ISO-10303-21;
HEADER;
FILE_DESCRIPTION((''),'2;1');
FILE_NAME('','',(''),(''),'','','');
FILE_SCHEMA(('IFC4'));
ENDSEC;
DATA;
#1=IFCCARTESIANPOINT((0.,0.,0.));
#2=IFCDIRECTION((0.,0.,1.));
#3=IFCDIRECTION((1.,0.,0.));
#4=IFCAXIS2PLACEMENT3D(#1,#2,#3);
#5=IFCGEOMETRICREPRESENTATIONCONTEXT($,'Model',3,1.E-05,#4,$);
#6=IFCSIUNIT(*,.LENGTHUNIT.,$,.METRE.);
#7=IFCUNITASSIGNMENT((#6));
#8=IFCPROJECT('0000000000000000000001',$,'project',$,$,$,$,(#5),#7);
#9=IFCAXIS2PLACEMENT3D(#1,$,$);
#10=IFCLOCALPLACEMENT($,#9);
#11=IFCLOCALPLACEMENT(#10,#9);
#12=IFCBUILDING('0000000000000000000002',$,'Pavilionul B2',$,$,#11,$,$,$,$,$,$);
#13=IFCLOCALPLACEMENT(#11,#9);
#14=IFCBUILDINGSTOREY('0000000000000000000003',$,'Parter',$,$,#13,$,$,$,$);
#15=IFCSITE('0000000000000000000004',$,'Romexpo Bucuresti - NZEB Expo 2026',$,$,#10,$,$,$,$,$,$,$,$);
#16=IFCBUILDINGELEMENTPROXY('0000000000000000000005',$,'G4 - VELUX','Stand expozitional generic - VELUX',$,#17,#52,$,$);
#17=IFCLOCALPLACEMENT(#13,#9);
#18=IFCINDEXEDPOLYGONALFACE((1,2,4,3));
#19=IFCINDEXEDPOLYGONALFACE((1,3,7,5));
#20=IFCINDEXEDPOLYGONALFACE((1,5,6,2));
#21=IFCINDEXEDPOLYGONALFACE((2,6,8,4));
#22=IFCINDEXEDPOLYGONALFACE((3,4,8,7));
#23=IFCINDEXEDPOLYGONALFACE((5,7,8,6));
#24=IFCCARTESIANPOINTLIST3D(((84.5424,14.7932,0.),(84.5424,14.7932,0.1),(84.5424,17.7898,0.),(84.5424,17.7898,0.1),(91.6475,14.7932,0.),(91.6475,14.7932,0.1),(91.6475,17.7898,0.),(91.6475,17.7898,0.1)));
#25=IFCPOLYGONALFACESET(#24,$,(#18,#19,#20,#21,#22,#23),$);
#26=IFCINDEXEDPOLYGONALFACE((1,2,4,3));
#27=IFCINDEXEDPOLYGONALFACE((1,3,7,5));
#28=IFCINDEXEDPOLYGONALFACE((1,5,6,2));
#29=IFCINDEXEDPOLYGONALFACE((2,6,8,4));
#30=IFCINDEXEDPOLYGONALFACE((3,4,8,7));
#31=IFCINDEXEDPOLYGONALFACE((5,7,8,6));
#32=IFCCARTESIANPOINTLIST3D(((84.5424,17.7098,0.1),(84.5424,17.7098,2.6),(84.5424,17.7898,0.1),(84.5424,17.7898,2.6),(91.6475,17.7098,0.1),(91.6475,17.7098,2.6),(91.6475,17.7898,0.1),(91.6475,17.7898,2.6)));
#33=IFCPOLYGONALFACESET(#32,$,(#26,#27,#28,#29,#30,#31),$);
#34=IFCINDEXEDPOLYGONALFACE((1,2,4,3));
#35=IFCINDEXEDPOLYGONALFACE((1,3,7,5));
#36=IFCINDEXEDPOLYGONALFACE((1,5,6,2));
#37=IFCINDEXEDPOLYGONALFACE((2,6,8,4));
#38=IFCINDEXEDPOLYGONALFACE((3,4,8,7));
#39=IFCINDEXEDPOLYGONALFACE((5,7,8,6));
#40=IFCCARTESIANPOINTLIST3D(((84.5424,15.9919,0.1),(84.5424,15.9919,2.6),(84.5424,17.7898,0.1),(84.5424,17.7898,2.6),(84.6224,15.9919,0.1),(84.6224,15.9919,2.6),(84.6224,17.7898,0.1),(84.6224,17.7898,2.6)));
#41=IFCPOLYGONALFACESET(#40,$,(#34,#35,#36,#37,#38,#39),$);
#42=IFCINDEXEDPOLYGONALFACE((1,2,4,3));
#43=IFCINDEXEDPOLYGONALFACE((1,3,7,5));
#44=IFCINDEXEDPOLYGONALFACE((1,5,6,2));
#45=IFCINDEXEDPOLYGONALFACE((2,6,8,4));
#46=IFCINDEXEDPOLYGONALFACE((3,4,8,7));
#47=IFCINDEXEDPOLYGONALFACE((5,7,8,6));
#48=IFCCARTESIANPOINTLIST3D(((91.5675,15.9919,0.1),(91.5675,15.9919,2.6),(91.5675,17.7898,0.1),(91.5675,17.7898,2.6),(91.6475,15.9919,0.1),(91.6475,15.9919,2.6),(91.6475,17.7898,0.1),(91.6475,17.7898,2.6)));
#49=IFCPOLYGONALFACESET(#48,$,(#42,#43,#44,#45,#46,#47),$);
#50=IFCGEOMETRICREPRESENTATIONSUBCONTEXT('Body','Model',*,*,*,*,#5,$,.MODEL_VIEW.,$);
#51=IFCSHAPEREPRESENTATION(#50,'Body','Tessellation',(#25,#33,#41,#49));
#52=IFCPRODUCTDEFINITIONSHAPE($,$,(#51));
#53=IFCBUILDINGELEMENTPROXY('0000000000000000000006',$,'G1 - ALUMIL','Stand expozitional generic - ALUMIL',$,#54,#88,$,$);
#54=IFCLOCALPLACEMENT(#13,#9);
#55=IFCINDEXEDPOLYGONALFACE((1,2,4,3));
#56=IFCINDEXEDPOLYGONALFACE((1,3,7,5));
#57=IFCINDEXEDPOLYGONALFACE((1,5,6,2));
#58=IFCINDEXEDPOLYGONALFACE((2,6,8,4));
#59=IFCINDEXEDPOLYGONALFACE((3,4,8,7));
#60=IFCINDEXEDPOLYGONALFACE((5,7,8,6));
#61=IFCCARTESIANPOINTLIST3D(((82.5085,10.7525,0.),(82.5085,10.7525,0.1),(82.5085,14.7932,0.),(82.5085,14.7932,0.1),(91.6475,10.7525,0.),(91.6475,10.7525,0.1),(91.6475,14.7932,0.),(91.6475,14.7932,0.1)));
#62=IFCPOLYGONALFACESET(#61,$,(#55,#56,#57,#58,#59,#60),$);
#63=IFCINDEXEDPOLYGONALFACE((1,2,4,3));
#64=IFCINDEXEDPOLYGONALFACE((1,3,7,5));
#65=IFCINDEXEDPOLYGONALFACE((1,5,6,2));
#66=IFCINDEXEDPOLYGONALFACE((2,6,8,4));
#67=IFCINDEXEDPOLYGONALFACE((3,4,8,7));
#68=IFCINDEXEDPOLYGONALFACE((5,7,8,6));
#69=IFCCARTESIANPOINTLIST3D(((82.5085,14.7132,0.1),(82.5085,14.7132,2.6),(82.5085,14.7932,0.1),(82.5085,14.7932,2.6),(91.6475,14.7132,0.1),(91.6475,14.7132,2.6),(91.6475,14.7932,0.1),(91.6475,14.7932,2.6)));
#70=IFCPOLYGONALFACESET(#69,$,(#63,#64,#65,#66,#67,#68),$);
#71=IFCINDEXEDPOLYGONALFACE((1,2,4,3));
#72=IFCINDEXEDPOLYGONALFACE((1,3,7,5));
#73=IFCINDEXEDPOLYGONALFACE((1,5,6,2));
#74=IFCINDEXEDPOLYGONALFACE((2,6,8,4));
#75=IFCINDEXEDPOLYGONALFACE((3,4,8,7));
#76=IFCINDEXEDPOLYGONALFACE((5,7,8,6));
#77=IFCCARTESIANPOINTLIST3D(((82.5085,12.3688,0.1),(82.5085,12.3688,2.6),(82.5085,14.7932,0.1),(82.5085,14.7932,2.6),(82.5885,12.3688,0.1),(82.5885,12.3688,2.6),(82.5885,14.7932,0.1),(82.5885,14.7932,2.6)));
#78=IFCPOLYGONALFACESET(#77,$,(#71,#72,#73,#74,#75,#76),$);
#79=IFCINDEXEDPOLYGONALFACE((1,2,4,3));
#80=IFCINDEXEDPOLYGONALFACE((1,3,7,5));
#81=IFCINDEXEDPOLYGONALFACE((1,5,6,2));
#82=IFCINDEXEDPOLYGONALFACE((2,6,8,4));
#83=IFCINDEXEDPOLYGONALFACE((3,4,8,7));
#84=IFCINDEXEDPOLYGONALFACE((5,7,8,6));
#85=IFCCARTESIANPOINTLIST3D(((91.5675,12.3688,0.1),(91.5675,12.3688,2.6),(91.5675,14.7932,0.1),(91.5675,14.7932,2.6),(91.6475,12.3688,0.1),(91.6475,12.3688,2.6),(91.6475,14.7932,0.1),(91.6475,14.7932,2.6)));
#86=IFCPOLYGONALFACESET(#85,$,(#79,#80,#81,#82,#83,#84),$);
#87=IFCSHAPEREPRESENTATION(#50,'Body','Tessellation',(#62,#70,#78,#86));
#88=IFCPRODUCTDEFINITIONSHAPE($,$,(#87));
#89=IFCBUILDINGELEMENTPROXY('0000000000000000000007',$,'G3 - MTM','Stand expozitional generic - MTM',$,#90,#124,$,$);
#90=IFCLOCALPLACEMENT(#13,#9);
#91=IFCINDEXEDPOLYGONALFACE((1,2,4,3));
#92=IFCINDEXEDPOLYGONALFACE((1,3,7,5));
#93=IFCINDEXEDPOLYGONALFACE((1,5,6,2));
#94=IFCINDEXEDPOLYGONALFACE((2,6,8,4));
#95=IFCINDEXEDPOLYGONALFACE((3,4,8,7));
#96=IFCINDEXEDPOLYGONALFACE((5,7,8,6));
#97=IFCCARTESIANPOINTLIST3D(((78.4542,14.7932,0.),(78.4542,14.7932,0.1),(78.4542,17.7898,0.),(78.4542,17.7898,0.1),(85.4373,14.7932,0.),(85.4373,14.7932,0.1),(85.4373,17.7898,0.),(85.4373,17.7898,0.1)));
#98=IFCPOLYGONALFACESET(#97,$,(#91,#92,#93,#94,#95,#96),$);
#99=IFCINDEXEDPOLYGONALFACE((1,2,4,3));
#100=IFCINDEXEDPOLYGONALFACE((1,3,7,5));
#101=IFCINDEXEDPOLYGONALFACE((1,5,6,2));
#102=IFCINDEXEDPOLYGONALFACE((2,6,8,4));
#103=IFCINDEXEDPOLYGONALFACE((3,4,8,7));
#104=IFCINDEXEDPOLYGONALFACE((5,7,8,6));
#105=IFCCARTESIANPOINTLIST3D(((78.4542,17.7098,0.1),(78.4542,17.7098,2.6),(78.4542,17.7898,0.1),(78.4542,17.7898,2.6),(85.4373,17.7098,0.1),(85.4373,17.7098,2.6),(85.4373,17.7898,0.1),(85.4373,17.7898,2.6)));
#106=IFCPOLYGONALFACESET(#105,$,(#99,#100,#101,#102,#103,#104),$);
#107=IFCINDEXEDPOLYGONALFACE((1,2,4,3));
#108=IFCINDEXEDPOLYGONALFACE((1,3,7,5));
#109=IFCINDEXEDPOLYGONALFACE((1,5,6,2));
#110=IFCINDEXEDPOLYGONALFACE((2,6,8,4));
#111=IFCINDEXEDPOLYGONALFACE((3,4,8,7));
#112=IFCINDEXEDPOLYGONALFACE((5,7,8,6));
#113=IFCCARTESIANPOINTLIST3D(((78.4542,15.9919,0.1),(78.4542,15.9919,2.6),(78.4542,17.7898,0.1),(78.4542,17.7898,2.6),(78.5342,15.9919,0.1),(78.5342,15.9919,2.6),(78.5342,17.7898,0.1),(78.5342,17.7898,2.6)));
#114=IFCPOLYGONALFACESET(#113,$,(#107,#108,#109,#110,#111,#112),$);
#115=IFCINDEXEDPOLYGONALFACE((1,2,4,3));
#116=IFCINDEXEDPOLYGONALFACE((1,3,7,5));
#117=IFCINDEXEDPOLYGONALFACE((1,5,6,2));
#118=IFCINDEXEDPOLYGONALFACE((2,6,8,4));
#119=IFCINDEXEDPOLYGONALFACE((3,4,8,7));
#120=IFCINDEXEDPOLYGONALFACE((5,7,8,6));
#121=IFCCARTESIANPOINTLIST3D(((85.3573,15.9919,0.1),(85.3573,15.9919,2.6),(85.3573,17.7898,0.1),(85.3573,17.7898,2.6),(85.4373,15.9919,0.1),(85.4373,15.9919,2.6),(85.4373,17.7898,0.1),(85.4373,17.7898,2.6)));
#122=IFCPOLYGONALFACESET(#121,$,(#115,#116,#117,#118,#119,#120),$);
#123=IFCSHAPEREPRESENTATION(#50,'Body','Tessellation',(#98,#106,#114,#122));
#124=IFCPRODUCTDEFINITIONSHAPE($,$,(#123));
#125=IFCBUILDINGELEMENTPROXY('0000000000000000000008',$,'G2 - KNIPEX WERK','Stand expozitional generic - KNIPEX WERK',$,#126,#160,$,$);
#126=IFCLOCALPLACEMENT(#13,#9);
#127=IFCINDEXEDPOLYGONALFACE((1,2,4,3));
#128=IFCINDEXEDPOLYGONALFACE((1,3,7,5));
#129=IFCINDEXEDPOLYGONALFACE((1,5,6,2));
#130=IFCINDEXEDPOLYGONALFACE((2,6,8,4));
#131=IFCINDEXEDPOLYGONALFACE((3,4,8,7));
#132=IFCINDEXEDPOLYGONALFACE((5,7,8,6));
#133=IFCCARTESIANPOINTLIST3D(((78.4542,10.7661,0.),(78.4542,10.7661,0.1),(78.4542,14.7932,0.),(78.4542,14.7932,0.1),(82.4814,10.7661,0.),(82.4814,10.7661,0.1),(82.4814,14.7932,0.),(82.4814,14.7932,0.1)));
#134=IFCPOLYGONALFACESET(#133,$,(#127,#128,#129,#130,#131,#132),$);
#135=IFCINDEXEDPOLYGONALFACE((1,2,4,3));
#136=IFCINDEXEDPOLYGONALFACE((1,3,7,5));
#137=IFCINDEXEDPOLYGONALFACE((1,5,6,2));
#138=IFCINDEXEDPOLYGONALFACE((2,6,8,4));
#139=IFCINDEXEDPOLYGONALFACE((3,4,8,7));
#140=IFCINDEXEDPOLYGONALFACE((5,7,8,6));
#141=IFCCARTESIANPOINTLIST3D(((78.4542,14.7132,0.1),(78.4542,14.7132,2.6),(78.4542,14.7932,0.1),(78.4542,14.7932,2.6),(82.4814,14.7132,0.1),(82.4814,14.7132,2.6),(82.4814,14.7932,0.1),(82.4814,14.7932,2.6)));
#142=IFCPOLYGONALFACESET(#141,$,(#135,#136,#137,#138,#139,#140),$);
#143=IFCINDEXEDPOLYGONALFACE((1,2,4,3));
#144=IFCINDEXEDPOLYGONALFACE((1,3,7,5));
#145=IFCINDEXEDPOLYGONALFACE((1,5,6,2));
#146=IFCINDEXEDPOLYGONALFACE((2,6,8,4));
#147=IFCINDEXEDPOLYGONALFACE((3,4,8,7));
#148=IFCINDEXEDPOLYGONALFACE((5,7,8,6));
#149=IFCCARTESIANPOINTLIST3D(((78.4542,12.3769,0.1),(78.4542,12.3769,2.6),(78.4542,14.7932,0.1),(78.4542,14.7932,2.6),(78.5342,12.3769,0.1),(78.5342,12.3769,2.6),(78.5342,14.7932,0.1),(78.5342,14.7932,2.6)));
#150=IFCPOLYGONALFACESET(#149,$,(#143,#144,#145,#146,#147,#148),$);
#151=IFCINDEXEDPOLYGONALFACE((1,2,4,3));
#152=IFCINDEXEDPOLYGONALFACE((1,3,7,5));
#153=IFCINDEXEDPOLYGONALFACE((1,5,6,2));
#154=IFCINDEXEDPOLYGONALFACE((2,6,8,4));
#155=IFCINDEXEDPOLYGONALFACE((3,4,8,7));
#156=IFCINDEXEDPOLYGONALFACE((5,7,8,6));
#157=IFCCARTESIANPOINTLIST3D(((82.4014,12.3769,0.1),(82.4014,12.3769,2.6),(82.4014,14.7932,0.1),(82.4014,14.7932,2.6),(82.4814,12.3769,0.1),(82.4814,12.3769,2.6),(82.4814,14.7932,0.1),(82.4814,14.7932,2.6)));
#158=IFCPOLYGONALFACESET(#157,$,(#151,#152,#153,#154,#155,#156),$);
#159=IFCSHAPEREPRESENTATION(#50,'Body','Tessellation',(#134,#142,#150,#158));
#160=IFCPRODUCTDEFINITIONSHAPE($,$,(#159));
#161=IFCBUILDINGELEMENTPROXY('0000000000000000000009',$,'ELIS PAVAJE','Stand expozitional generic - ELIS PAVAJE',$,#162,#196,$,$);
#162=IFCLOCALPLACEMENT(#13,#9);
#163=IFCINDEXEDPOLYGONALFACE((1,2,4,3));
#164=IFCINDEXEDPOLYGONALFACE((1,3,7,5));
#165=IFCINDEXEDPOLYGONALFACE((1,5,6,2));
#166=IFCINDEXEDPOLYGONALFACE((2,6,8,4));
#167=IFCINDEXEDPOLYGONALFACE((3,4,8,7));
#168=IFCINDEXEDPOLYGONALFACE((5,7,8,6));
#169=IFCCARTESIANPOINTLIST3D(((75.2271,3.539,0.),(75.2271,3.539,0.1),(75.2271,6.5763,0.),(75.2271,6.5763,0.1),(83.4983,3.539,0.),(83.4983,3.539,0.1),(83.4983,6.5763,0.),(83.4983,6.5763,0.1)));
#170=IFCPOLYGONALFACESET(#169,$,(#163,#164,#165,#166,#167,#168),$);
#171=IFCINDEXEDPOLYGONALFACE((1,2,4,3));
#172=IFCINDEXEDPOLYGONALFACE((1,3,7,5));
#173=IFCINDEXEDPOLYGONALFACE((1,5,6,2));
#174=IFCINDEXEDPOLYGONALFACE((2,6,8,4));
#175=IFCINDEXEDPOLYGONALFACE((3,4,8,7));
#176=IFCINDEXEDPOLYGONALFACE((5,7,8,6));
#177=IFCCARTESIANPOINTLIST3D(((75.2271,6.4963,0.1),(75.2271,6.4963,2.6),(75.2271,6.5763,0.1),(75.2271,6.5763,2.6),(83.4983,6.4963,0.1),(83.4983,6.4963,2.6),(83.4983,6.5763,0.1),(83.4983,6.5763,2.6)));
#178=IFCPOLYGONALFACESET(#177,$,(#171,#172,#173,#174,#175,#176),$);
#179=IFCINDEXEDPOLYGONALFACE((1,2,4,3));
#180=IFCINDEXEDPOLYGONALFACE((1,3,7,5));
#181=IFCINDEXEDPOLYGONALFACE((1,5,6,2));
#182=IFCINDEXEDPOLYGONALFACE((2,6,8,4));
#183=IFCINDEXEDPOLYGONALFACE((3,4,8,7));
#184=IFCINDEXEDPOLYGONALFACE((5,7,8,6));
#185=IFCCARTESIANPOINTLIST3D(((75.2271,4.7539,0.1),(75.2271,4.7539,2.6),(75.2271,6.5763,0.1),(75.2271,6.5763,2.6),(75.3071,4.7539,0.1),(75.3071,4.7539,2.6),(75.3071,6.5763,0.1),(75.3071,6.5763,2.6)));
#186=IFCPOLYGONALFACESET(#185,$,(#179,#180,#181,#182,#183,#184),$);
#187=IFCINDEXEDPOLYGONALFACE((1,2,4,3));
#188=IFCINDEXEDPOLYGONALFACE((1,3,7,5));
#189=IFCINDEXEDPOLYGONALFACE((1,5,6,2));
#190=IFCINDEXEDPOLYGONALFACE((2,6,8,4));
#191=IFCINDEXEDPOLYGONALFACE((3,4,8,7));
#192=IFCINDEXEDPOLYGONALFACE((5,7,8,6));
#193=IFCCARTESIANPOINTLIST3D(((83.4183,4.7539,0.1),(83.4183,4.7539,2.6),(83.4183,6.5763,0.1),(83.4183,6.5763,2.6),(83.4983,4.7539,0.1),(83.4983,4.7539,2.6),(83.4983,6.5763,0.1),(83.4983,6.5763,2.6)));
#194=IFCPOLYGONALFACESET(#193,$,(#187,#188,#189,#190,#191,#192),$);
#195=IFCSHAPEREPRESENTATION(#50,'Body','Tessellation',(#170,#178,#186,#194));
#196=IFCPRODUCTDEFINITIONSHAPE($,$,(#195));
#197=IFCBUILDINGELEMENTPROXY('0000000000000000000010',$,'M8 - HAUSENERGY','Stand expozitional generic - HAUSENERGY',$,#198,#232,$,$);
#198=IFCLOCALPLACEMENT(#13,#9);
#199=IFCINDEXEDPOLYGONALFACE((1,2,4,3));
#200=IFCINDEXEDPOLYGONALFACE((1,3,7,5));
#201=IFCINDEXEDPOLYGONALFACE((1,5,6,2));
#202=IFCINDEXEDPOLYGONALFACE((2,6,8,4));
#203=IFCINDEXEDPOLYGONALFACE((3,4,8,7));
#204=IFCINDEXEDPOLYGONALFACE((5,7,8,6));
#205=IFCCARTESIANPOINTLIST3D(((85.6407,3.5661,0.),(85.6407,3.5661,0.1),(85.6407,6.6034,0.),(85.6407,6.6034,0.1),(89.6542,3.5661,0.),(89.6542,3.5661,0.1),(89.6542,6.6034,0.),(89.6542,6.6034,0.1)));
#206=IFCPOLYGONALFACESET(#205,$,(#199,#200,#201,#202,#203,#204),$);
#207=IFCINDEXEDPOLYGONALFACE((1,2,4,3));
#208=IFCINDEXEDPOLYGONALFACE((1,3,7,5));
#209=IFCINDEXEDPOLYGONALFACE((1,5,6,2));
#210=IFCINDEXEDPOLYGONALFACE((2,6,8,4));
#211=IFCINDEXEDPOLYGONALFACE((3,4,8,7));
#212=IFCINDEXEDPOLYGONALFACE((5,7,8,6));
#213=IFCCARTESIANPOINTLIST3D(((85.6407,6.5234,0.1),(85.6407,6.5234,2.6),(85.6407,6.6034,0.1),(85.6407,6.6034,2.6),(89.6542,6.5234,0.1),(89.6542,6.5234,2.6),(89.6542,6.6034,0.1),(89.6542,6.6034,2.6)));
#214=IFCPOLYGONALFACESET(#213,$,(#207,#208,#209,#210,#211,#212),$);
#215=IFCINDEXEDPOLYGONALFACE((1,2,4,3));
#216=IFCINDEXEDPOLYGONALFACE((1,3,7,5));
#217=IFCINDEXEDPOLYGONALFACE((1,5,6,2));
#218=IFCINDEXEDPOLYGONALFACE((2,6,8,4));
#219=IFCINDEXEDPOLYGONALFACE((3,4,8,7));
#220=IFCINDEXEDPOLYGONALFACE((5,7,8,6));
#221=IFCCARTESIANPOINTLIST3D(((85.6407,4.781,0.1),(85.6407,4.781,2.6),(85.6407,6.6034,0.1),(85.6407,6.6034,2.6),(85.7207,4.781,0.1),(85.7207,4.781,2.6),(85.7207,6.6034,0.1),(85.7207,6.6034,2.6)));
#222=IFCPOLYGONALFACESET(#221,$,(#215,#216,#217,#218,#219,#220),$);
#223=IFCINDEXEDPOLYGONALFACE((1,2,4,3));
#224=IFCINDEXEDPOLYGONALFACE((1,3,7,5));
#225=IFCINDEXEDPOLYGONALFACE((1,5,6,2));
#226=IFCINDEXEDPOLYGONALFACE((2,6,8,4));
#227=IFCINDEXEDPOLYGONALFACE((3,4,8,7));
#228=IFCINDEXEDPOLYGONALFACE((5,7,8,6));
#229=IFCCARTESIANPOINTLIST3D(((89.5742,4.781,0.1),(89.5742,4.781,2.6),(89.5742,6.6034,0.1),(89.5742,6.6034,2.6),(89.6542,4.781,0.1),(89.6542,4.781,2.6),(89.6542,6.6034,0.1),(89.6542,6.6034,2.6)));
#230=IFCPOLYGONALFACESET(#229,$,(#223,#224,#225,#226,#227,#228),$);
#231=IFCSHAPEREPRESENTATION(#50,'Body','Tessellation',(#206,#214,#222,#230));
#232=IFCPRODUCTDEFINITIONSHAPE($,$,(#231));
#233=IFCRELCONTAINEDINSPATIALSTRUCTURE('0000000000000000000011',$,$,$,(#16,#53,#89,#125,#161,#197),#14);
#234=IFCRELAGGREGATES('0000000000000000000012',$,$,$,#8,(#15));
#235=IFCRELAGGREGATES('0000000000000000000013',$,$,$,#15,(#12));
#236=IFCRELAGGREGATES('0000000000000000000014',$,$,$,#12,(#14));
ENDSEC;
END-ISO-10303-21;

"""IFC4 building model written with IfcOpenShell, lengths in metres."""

from ifc_helpers import new_model, si_unit, frame, frame_2d, origin, origin_with_axes, place, context, subcontext, project, spatial, rectangle, extrude, element, save


model = new_model("IFC4")

# Units and contexts
model_context = context("Model", 3, precision=1e-05, world=origin_with_axes())
body_context = subcontext(model_context, "Body", "Model", "MODEL_VIEW")
ifc_project = project(units=[si_unit("LENGTHUNIT", "METRE")], contexts=[model_context])

# Site, building, storey
site_placement = place(None, origin())
site = spatial("IfcSite", under=ifc_project, at=site_placement, Name="Romexpo Bucuresti - NZEB Expo 2026")
building_placement = place(site_placement, origin())
building = spatial("IfcBuilding", under=site, at=building_placement, Name="Pavilionul B2")
storey_placement = place(building_placement, origin())
storey = spatial("IfcBuildingStorey", under=building, at=storey_placement, Name="Parter")

# Building element proxies
proxy_1_placement = place(storey_placement, frame((84.5424, 14.7932, 0.0), z_axis=(0.0, 0.0, 1.0), x_axis=(1.0, 0.0, 0.0)))
element("IfcBuildingElementProxy", 1, at=proxy_1_placement, inside=storey, Name="G4 - VELUX", Description="Stand expozitional generic - VELUX", context=body_context, shape_type="SweptSolid", body=[
    extrude(rectangle(XDim=7.1051, YDim=2.9966, at=frame_2d((3.5525, 1.4983))), origin(), (0.0, 0.0, 1.0), 0.1),
    extrude(rectangle(XDim=7.1051, YDim=0.08, at=frame_2d((3.5525, 2.9566))), frame((0.0, 0.0, 0.1)), (0.0, 0.0, 1.0), 2.5),
    extrude(rectangle(XDim=0.08, YDim=1.798, at=frame_2d((0.04, 2.0976))), frame((0.0, 0.0, 0.1)), (0.0, 0.0, 1.0), 2.5),
    extrude(rectangle(XDim=0.08, YDim=1.798, at=frame_2d((7.0651, 2.0976))), frame((0.0, 0.0, 0.1)), (0.0, 0.0, 1.0), 2.5),
])
proxy_2_placement = place(storey_placement, frame((82.5085, 10.7525, 0.0), z_axis=(0.0, 0.0, 1.0), x_axis=(1.0, 0.0, 0.0)))
element("IfcBuildingElementProxy", 2, at=proxy_2_placement, inside=storey, Name="G1 - ALUMIL", Description="Stand expozitional generic - ALUMIL", context=body_context, shape_type="SweptSolid", body=[
    extrude(rectangle(XDim=9.139, YDim=4.0407, at=frame_2d((4.5695, 2.0203))), origin(), (0.0, 0.0, 1.0), 0.1),
    extrude(rectangle(XDim=9.139, YDim=0.08, at=frame_2d((4.5695, 4.0007))), frame((0.0, 0.0, 0.1)), (0.0, 0.0, 1.0), 2.5),
    extrude(rectangle(XDim=0.08, YDim=2.4244, at=frame_2d((0.04, 2.8285))), frame((0.0, 0.0, 0.1)), (0.0, 0.0, 1.0), 2.5),
    extrude(rectangle(XDim=0.08, YDim=2.4244, at=frame_2d((9.099, 2.8285))), frame((0.0, 0.0, 0.1)), (0.0, 0.0, 1.0), 2.5),
])
proxy_3_placement = place(storey_placement, frame((78.4542, 14.7932, 0.0), z_axis=(0.0, 0.0, 1.0), x_axis=(1.0, 0.0, 0.0)))
element("IfcBuildingElementProxy", 3, at=proxy_3_placement, inside=storey, Name="G3 - MTM", Description="Stand expozitional generic - MTM", context=body_context, shape_type="SweptSolid", body=[
    extrude(rectangle(XDim=6.9831, YDim=2.9966, at=frame_2d((3.4915, 1.4983))), origin(), (0.0, 0.0, 1.0), 0.1),
    extrude(rectangle(XDim=6.9831, YDim=0.08, at=frame_2d((3.4915, 2.9566))), frame((0.0, 0.0, 0.1)), (0.0, 0.0, 1.0), 2.5),
    extrude(rectangle(XDim=0.08, YDim=1.798, at=frame_2d((0.04, 2.0976))), frame((0.0, 0.0, 0.1)), (0.0, 0.0, 1.0), 2.5),
    extrude(rectangle(XDim=0.08, YDim=1.798, at=frame_2d((6.9431, 2.0976))), frame((0.0, 0.0, 0.1)), (0.0, 0.0, 1.0), 2.5),
])
proxy_4_placement = place(storey_placement, frame((78.4542, 10.7661, 0.0), z_axis=(0.0, 0.0, 1.0), x_axis=(1.0, 0.0, 0.0)))
element("IfcBuildingElementProxy", 4, at=proxy_4_placement, inside=storey, Name="G2 - KNIPEX WERK", Description="Stand expozitional generic - KNIPEX WERK", context=body_context, shape_type="SweptSolid", body=[
    extrude(rectangle(XDim=4.0271, YDim=4.0271, at=frame_2d((2.0136, 2.0136))), origin(), (0.0, 0.0, 1.0), 0.1),
    extrude(rectangle(XDim=4.0271, YDim=0.08, at=frame_2d((2.0136, 3.9871))), frame((0.0, 0.0, 0.1)), (0.0, 0.0, 1.0), 2.5),
    extrude(rectangle(XDim=0.08, YDim=2.4163, at=frame_2d((0.04, 2.819))), frame((0.0, 0.0, 0.1)), (0.0, 0.0, 1.0), 2.5),
    extrude(rectangle(XDim=0.08, YDim=2.4163, at=frame_2d((3.9871, 2.819))), frame((0.0, 0.0, 0.1)), (0.0, 0.0, 1.0), 2.5),
])
proxy_5_placement = place(storey_placement, frame((75.2271, 3.539, 0.0), z_axis=(0.0, 0.0, 1.0), x_axis=(1.0, 0.0, 0.0)))
element("IfcBuildingElementProxy", 5, at=proxy_5_placement, inside=storey, Name="ELIS PAVAJE", Description="Stand expozitional generic - ELIS PAVAJE", context=body_context, shape_type="SweptSolid", body=[
    extrude(rectangle(XDim=8.2712, YDim=3.0373, at=frame_2d((4.1356, 1.5186))), origin(), (0.0, 0.0, 1.0), 0.1),
    extrude(rectangle(XDim=8.2712, YDim=0.08, at=frame_2d((4.1356, 2.9973))), frame((0.0, 0.0, 0.1)), (0.0, 0.0, 1.0), 2.5),
    extrude(rectangle(XDim=0.08, YDim=1.8224, at=frame_2d((0.04, 2.1261))), frame((0.0, 0.0, 0.1)), (0.0, 0.0, 1.0), 2.5),
    extrude(rectangle(XDim=0.08, YDim=1.8224, at=frame_2d((8.2312, 2.1261))), frame((0.0, 0.0, 0.1)), (0.0, 0.0, 1.0), 2.5),
])
proxy_6_placement = place(storey_placement, frame((85.6407, 3.5661, 0.0), z_axis=(0.0, 0.0, 1.0), x_axis=(1.0, 0.0, 0.0)))
element("IfcBuildingElementProxy", 6, at=proxy_6_placement, inside=storey, Name="M8 - HAUSENERGY", Description="Stand expozitional generic - HAUSENERGY", context=body_context, shape_type="SweptSolid", body=[
    extrude(rectangle(XDim=4.0136, YDim=3.0373, at=frame_2d((2.0068, 1.5186))), origin(), (0.0, 0.0, 1.0), 0.1),
    extrude(rectangle(XDim=4.0136, YDim=0.08, at=frame_2d((2.0068, 2.9973))), frame((0.0, 0.0, 0.1)), (0.0, 0.0, 1.0), 2.5),
    extrude(rectangle(XDim=0.08, YDim=1.8224, at=frame_2d((0.04, 2.1261))), frame((0.0, 0.0, 0.1)), (0.0, 0.0, 1.0), 2.5),
    extrude(rectangle(XDim=0.08, YDim=1.8224, at=frame_2d((3.9736, 2.1261))), frame((0.0, 0.0, 0.1)), (0.0, 0.0, 1.0), 2.5),
])

save(model, "model.ifc")
